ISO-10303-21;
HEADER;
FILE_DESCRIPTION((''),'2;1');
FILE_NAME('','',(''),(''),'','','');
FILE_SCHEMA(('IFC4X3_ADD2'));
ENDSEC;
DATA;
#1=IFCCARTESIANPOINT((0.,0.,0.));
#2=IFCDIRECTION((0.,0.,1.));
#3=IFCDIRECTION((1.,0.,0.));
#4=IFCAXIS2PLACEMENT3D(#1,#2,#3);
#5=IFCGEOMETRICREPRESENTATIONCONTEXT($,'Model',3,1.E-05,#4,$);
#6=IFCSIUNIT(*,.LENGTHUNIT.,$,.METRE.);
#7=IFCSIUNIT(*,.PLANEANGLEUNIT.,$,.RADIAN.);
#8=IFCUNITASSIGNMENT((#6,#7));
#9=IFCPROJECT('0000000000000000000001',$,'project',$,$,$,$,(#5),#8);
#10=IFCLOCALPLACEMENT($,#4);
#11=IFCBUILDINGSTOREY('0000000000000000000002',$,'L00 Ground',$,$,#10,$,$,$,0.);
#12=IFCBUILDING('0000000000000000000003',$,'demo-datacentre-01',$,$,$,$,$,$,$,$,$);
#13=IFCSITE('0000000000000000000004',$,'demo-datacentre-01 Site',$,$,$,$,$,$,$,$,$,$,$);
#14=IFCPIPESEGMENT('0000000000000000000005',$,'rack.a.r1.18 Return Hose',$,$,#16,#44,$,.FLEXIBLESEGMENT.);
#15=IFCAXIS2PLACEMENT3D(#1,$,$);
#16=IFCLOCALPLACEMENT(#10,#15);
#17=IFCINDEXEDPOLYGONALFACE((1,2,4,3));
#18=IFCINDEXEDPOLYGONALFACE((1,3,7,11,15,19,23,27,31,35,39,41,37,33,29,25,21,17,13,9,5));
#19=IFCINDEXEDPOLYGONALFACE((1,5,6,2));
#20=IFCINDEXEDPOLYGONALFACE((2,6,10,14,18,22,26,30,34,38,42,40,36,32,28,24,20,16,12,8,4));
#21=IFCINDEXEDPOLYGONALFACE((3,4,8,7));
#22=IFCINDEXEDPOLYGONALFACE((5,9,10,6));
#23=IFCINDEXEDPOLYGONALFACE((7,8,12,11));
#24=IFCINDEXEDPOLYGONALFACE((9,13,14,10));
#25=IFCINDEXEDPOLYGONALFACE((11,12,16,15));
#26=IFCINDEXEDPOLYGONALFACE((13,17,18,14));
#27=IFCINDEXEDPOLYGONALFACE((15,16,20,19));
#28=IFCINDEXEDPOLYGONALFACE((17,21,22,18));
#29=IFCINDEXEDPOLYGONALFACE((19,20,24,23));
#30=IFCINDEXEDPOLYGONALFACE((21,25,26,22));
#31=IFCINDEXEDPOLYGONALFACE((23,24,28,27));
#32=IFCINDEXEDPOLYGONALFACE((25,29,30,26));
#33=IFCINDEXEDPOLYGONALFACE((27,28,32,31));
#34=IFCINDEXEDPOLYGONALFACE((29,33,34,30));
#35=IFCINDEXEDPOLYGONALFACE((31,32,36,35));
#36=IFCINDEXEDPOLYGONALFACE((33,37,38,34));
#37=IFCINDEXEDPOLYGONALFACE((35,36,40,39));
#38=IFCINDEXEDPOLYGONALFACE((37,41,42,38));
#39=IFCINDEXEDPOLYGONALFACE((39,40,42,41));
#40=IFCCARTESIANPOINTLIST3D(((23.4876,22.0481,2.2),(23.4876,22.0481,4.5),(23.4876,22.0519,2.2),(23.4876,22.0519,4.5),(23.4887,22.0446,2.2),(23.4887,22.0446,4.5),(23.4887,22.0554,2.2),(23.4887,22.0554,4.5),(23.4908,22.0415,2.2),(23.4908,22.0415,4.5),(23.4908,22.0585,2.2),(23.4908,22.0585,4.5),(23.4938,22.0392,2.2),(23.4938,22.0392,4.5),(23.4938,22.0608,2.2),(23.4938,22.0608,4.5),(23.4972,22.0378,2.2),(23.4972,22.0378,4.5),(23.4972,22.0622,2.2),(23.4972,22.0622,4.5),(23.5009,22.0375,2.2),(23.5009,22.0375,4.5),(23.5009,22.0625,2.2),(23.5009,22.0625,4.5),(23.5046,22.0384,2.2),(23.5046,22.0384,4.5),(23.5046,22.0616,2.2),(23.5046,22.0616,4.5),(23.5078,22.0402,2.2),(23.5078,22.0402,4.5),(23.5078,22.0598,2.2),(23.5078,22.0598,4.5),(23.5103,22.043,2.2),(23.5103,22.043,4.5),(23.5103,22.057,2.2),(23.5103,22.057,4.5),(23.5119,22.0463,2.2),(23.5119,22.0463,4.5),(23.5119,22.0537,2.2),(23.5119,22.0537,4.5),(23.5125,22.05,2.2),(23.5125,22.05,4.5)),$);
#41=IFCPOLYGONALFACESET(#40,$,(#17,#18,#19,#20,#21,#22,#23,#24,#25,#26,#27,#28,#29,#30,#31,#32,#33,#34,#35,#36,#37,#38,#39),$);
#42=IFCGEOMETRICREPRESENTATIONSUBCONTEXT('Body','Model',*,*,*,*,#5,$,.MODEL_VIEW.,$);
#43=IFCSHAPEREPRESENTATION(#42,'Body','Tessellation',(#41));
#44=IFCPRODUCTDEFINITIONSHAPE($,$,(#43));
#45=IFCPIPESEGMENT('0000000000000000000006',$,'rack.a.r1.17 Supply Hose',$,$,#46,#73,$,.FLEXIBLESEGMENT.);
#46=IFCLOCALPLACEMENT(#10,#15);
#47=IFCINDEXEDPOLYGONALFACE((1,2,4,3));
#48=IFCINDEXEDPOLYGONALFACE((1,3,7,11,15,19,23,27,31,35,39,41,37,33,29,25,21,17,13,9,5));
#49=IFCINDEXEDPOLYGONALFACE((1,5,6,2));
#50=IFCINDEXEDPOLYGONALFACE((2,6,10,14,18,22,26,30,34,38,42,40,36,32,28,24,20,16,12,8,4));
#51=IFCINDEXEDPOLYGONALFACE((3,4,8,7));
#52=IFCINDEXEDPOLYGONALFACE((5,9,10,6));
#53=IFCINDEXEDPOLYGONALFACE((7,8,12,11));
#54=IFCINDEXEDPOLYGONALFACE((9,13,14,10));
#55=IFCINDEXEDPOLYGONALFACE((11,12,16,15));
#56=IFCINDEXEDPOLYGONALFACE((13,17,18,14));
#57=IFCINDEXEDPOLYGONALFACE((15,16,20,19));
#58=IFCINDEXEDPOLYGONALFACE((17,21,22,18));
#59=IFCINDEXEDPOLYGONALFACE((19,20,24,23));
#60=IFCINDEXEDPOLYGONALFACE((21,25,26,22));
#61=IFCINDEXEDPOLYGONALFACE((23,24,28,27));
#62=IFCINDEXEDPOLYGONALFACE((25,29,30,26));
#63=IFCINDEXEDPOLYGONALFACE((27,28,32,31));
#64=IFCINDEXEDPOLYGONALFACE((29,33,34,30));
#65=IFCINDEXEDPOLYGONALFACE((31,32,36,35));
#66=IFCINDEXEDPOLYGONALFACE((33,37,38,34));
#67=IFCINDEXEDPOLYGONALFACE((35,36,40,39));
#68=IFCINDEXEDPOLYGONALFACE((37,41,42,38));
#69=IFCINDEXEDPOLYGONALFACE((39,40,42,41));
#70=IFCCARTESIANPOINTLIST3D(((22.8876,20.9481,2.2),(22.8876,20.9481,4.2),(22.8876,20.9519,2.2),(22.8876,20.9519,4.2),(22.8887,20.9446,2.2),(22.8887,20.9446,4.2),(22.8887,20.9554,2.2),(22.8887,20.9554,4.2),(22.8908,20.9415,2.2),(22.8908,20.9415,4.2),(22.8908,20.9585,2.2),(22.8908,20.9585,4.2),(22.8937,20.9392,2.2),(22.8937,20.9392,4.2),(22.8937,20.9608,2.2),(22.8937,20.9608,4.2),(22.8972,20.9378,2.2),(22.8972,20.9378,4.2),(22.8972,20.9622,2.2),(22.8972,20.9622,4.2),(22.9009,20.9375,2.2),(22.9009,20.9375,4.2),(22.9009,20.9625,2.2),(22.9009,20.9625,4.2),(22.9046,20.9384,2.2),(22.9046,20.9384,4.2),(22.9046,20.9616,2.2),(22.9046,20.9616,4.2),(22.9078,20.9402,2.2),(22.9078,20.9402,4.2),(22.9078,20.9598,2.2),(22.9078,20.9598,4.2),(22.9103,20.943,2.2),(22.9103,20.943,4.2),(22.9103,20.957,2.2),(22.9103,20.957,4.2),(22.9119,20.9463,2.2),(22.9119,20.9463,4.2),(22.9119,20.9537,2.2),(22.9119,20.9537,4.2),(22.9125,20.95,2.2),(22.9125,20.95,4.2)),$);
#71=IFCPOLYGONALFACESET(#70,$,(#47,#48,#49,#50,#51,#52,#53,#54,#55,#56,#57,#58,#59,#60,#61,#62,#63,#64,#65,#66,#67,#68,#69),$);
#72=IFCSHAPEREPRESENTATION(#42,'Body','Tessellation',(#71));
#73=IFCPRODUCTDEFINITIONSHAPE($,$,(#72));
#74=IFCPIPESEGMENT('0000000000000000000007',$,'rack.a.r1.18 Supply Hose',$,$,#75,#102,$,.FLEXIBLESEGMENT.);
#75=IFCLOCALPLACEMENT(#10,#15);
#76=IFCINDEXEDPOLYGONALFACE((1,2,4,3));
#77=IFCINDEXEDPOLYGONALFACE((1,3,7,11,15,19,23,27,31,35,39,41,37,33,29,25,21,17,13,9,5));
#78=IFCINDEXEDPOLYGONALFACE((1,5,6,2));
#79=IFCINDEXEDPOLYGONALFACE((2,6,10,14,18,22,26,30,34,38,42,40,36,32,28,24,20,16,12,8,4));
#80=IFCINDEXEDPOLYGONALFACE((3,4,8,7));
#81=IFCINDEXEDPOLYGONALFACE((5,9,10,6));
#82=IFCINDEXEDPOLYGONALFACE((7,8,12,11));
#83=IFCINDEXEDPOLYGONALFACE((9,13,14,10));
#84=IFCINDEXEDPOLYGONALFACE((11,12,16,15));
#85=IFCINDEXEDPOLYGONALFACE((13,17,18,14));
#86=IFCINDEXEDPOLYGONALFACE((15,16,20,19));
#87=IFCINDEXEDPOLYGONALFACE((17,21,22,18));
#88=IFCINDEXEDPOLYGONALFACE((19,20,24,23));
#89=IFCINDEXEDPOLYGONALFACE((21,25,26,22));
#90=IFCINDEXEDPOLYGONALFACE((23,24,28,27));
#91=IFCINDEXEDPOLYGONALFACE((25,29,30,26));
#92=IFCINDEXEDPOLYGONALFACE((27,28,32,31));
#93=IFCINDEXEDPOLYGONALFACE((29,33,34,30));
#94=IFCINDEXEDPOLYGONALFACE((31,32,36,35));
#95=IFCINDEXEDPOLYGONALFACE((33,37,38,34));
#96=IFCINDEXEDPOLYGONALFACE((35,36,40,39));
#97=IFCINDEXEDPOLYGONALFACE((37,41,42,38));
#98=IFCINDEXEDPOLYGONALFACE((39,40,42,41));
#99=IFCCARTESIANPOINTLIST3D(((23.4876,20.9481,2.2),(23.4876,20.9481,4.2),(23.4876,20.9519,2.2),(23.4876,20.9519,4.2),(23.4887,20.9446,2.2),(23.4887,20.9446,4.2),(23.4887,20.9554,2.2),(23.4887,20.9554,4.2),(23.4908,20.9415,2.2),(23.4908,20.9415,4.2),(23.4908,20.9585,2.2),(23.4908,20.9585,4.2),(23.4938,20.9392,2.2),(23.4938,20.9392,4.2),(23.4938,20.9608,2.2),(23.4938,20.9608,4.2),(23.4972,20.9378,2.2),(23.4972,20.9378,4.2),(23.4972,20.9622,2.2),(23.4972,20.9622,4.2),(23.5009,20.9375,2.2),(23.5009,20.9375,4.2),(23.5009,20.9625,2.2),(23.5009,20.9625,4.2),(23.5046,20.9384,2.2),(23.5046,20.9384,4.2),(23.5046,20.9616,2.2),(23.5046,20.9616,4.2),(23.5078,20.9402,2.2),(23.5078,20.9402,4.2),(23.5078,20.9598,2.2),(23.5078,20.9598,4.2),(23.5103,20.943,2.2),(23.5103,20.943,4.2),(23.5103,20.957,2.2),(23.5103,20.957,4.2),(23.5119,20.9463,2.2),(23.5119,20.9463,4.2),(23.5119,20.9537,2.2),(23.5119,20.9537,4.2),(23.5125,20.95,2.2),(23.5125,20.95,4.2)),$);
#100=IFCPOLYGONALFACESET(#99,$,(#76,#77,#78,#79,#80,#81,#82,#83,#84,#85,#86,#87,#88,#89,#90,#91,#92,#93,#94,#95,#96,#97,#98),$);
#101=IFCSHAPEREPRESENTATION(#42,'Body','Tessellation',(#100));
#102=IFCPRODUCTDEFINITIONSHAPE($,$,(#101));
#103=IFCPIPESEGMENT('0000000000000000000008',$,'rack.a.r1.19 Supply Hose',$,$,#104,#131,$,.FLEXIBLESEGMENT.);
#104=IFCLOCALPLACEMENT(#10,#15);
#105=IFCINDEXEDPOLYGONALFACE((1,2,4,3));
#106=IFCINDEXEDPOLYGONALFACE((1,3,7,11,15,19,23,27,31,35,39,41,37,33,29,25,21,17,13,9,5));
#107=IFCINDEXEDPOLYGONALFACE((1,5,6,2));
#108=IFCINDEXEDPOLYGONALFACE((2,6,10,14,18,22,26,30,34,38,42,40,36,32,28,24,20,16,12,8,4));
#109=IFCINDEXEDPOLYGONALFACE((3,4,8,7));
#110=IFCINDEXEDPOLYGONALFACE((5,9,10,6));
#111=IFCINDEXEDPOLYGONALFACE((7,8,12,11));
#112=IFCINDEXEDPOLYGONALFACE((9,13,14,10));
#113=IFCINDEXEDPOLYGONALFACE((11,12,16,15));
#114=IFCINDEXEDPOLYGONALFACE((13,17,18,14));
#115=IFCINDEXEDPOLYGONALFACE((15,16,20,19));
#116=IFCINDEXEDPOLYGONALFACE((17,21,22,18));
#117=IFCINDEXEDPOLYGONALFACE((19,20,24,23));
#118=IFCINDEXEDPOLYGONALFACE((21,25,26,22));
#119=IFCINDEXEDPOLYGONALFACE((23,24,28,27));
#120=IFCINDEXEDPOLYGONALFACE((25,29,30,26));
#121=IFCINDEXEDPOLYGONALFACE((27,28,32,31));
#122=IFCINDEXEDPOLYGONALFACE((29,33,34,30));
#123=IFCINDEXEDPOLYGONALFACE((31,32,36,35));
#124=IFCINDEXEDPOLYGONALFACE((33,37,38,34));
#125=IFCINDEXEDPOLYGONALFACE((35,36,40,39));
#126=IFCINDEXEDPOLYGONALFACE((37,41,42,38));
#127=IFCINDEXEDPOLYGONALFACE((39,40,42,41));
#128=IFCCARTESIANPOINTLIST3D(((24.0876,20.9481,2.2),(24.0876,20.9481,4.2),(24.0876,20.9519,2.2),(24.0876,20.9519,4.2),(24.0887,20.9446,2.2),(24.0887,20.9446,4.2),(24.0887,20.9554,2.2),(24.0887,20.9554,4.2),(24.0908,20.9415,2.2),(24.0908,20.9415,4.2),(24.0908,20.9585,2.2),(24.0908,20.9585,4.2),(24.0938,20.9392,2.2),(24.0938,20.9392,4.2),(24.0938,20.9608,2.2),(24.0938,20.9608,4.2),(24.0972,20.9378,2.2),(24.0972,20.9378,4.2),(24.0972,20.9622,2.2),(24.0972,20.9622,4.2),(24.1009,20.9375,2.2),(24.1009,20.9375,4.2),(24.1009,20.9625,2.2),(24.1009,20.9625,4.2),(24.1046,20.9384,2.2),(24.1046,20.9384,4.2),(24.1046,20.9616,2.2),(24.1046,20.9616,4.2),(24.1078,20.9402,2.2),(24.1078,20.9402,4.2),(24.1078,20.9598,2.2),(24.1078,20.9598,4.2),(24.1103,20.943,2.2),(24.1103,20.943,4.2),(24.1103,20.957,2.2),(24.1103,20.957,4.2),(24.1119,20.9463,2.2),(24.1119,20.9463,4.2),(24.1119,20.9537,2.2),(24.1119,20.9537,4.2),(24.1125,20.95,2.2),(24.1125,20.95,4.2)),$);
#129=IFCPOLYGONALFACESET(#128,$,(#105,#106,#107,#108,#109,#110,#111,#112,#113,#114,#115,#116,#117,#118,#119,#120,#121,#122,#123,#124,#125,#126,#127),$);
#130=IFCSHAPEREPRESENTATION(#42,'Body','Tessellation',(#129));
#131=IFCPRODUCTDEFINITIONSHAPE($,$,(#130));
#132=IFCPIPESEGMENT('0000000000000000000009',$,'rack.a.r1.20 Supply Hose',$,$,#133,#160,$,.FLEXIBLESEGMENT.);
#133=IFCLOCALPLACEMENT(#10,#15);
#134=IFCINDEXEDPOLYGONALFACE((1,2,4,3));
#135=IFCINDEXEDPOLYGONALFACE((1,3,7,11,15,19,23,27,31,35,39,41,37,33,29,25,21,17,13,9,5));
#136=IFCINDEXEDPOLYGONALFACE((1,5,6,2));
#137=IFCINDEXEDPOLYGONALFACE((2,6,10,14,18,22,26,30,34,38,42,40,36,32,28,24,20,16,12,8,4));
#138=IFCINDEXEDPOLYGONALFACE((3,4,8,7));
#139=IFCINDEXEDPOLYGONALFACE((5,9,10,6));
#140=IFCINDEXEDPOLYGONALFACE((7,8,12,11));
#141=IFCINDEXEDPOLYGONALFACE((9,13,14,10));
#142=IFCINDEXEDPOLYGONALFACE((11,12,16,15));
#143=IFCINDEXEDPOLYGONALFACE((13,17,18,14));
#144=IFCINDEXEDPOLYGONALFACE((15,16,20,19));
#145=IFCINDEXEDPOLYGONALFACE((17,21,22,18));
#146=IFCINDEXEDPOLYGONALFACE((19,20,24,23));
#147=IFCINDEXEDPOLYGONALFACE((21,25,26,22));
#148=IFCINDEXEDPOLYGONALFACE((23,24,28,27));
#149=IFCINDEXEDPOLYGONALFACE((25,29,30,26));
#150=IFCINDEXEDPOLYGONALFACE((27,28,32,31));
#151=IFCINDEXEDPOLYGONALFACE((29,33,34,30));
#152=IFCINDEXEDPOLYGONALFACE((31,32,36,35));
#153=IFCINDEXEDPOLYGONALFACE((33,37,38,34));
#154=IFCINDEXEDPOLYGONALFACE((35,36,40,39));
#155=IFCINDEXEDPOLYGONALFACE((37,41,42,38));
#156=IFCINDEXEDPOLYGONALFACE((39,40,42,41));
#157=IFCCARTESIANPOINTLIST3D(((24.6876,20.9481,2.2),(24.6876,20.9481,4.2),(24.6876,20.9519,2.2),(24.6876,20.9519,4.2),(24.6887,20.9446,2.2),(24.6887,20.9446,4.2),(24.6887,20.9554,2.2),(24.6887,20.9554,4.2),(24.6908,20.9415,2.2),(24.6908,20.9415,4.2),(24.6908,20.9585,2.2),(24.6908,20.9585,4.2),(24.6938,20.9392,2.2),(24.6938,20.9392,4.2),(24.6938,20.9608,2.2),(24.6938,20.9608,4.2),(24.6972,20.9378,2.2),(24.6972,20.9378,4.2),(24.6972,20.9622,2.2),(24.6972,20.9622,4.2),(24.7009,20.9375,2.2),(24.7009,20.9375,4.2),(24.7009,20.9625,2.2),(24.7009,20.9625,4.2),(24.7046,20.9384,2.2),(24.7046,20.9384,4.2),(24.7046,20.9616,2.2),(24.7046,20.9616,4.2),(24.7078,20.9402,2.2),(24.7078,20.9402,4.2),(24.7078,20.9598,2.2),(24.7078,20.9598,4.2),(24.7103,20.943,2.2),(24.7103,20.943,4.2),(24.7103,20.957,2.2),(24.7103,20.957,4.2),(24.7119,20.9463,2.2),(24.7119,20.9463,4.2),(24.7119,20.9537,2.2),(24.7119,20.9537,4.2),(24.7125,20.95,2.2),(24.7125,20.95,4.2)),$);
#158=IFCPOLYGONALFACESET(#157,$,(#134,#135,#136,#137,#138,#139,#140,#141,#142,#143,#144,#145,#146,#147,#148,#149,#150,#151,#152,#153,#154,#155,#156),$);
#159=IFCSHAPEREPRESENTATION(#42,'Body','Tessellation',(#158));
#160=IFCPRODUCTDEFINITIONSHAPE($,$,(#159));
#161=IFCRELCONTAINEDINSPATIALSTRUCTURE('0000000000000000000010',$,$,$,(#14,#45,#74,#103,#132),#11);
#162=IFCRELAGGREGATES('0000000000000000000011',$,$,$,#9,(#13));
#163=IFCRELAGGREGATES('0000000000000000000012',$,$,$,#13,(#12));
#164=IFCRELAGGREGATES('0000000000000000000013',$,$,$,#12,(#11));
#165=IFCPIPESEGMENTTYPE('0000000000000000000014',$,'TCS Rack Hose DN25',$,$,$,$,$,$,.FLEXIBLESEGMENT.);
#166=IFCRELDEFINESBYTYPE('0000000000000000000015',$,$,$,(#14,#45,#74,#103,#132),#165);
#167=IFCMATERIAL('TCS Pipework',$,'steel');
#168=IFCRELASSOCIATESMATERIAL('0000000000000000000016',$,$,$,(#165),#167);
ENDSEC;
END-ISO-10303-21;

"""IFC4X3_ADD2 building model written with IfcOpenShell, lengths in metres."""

from ifc_helpers import new_model, si_unit, frame, origin_with_axes, place, context, subcontext, project, spatial, circle, extrude, material, type_object, element, save


model = new_model("IFC4X3_ADD2")

# Units and contexts
model_context = context("Model", 3, precision=1e-05, world=origin_with_axes())
body_context = subcontext(model_context, "Body", "Model", "MODEL_VIEW")
ifc_project = project(units=[si_unit("LENGTHUNIT", "METRE"), si_unit("PLANEANGLEUNIT", "RADIAN")], contexts=[model_context])

# Site, building, storey
site = spatial("IfcSite", under=ifc_project, Name="demo-datacentre-01 Site")
building = spatial("IfcBuilding", under=site, Name="demo-datacentre-01")
storey_placement = place(None, origin_with_axes())
storey = spatial("IfcBuildingStorey", under=building, at=storey_placement, Name="L00 Ground", Elevation=0.0)

# Shared definitions
ifc_material = material(Name="TCS Pipework", Category="steel")

# Pipe segments
pipe_segment_type_1 = type_object("IfcPipeSegmentType", Name="TCS Rack Hose DN25", PredefinedType="FLEXIBLESEGMENT", material=ifc_material)
for number, where, z_axis, x_axis, name in (
    (1, (23.5, 22.05, 4.5), (0.0, 0.0, -1.0), (1.0, 0.0, 0.0), "rack.a.r1.18 Return Hose"),
):
    element("IfcPipeSegment", number, at=place(storey_placement, frame(where, z_axis=z_axis, x_axis=x_axis)), inside=storey, type_object=pipe_segment_type_1, Name=name, PredefinedType="FLEXIBLESEGMENT", context=body_context, shape_type="SweptSolid", body=[
        extrude(circle(Radius=0.0125), origin_with_axes(), (0.0, 0.0, 1.0), 2.3),
    ])
for number, where, z_axis, x_axis, name in (
    (2, (22.9, 20.95, 4.2), (0.0, 0.0, -1.0), (1.0, 0.0, 0.0), "rack.a.r1.17 Supply Hose"),
    (3, (23.5, 20.95, 4.2), (0.0, 0.0, -1.0), (1.0, 0.0, 0.0), "rack.a.r1.18 Supply Hose"),
    (4, (24.1, 20.95, 4.2), (0.0, 0.0, -1.0), (1.0, 0.0, 0.0), "rack.a.r1.19 Supply Hose"),
    (5, (24.7, 20.95, 4.2), (0.0, 0.0, -1.0), (1.0, 0.0, 0.0), "rack.a.r1.20 Supply Hose"),
):
    element("IfcPipeSegment", number, at=place(storey_placement, frame(where, z_axis=z_axis, x_axis=x_axis)), inside=storey, type_object=pipe_segment_type_1, Name=name, PredefinedType="FLEXIBLESEGMENT", context=body_context, shape_type="SweptSolid", body=[
        extrude(circle(Radius=0.0125), origin_with_axes(), (0.0, 0.0, 1.0), 2.0),
    ])

save(model, "model.ifc")
